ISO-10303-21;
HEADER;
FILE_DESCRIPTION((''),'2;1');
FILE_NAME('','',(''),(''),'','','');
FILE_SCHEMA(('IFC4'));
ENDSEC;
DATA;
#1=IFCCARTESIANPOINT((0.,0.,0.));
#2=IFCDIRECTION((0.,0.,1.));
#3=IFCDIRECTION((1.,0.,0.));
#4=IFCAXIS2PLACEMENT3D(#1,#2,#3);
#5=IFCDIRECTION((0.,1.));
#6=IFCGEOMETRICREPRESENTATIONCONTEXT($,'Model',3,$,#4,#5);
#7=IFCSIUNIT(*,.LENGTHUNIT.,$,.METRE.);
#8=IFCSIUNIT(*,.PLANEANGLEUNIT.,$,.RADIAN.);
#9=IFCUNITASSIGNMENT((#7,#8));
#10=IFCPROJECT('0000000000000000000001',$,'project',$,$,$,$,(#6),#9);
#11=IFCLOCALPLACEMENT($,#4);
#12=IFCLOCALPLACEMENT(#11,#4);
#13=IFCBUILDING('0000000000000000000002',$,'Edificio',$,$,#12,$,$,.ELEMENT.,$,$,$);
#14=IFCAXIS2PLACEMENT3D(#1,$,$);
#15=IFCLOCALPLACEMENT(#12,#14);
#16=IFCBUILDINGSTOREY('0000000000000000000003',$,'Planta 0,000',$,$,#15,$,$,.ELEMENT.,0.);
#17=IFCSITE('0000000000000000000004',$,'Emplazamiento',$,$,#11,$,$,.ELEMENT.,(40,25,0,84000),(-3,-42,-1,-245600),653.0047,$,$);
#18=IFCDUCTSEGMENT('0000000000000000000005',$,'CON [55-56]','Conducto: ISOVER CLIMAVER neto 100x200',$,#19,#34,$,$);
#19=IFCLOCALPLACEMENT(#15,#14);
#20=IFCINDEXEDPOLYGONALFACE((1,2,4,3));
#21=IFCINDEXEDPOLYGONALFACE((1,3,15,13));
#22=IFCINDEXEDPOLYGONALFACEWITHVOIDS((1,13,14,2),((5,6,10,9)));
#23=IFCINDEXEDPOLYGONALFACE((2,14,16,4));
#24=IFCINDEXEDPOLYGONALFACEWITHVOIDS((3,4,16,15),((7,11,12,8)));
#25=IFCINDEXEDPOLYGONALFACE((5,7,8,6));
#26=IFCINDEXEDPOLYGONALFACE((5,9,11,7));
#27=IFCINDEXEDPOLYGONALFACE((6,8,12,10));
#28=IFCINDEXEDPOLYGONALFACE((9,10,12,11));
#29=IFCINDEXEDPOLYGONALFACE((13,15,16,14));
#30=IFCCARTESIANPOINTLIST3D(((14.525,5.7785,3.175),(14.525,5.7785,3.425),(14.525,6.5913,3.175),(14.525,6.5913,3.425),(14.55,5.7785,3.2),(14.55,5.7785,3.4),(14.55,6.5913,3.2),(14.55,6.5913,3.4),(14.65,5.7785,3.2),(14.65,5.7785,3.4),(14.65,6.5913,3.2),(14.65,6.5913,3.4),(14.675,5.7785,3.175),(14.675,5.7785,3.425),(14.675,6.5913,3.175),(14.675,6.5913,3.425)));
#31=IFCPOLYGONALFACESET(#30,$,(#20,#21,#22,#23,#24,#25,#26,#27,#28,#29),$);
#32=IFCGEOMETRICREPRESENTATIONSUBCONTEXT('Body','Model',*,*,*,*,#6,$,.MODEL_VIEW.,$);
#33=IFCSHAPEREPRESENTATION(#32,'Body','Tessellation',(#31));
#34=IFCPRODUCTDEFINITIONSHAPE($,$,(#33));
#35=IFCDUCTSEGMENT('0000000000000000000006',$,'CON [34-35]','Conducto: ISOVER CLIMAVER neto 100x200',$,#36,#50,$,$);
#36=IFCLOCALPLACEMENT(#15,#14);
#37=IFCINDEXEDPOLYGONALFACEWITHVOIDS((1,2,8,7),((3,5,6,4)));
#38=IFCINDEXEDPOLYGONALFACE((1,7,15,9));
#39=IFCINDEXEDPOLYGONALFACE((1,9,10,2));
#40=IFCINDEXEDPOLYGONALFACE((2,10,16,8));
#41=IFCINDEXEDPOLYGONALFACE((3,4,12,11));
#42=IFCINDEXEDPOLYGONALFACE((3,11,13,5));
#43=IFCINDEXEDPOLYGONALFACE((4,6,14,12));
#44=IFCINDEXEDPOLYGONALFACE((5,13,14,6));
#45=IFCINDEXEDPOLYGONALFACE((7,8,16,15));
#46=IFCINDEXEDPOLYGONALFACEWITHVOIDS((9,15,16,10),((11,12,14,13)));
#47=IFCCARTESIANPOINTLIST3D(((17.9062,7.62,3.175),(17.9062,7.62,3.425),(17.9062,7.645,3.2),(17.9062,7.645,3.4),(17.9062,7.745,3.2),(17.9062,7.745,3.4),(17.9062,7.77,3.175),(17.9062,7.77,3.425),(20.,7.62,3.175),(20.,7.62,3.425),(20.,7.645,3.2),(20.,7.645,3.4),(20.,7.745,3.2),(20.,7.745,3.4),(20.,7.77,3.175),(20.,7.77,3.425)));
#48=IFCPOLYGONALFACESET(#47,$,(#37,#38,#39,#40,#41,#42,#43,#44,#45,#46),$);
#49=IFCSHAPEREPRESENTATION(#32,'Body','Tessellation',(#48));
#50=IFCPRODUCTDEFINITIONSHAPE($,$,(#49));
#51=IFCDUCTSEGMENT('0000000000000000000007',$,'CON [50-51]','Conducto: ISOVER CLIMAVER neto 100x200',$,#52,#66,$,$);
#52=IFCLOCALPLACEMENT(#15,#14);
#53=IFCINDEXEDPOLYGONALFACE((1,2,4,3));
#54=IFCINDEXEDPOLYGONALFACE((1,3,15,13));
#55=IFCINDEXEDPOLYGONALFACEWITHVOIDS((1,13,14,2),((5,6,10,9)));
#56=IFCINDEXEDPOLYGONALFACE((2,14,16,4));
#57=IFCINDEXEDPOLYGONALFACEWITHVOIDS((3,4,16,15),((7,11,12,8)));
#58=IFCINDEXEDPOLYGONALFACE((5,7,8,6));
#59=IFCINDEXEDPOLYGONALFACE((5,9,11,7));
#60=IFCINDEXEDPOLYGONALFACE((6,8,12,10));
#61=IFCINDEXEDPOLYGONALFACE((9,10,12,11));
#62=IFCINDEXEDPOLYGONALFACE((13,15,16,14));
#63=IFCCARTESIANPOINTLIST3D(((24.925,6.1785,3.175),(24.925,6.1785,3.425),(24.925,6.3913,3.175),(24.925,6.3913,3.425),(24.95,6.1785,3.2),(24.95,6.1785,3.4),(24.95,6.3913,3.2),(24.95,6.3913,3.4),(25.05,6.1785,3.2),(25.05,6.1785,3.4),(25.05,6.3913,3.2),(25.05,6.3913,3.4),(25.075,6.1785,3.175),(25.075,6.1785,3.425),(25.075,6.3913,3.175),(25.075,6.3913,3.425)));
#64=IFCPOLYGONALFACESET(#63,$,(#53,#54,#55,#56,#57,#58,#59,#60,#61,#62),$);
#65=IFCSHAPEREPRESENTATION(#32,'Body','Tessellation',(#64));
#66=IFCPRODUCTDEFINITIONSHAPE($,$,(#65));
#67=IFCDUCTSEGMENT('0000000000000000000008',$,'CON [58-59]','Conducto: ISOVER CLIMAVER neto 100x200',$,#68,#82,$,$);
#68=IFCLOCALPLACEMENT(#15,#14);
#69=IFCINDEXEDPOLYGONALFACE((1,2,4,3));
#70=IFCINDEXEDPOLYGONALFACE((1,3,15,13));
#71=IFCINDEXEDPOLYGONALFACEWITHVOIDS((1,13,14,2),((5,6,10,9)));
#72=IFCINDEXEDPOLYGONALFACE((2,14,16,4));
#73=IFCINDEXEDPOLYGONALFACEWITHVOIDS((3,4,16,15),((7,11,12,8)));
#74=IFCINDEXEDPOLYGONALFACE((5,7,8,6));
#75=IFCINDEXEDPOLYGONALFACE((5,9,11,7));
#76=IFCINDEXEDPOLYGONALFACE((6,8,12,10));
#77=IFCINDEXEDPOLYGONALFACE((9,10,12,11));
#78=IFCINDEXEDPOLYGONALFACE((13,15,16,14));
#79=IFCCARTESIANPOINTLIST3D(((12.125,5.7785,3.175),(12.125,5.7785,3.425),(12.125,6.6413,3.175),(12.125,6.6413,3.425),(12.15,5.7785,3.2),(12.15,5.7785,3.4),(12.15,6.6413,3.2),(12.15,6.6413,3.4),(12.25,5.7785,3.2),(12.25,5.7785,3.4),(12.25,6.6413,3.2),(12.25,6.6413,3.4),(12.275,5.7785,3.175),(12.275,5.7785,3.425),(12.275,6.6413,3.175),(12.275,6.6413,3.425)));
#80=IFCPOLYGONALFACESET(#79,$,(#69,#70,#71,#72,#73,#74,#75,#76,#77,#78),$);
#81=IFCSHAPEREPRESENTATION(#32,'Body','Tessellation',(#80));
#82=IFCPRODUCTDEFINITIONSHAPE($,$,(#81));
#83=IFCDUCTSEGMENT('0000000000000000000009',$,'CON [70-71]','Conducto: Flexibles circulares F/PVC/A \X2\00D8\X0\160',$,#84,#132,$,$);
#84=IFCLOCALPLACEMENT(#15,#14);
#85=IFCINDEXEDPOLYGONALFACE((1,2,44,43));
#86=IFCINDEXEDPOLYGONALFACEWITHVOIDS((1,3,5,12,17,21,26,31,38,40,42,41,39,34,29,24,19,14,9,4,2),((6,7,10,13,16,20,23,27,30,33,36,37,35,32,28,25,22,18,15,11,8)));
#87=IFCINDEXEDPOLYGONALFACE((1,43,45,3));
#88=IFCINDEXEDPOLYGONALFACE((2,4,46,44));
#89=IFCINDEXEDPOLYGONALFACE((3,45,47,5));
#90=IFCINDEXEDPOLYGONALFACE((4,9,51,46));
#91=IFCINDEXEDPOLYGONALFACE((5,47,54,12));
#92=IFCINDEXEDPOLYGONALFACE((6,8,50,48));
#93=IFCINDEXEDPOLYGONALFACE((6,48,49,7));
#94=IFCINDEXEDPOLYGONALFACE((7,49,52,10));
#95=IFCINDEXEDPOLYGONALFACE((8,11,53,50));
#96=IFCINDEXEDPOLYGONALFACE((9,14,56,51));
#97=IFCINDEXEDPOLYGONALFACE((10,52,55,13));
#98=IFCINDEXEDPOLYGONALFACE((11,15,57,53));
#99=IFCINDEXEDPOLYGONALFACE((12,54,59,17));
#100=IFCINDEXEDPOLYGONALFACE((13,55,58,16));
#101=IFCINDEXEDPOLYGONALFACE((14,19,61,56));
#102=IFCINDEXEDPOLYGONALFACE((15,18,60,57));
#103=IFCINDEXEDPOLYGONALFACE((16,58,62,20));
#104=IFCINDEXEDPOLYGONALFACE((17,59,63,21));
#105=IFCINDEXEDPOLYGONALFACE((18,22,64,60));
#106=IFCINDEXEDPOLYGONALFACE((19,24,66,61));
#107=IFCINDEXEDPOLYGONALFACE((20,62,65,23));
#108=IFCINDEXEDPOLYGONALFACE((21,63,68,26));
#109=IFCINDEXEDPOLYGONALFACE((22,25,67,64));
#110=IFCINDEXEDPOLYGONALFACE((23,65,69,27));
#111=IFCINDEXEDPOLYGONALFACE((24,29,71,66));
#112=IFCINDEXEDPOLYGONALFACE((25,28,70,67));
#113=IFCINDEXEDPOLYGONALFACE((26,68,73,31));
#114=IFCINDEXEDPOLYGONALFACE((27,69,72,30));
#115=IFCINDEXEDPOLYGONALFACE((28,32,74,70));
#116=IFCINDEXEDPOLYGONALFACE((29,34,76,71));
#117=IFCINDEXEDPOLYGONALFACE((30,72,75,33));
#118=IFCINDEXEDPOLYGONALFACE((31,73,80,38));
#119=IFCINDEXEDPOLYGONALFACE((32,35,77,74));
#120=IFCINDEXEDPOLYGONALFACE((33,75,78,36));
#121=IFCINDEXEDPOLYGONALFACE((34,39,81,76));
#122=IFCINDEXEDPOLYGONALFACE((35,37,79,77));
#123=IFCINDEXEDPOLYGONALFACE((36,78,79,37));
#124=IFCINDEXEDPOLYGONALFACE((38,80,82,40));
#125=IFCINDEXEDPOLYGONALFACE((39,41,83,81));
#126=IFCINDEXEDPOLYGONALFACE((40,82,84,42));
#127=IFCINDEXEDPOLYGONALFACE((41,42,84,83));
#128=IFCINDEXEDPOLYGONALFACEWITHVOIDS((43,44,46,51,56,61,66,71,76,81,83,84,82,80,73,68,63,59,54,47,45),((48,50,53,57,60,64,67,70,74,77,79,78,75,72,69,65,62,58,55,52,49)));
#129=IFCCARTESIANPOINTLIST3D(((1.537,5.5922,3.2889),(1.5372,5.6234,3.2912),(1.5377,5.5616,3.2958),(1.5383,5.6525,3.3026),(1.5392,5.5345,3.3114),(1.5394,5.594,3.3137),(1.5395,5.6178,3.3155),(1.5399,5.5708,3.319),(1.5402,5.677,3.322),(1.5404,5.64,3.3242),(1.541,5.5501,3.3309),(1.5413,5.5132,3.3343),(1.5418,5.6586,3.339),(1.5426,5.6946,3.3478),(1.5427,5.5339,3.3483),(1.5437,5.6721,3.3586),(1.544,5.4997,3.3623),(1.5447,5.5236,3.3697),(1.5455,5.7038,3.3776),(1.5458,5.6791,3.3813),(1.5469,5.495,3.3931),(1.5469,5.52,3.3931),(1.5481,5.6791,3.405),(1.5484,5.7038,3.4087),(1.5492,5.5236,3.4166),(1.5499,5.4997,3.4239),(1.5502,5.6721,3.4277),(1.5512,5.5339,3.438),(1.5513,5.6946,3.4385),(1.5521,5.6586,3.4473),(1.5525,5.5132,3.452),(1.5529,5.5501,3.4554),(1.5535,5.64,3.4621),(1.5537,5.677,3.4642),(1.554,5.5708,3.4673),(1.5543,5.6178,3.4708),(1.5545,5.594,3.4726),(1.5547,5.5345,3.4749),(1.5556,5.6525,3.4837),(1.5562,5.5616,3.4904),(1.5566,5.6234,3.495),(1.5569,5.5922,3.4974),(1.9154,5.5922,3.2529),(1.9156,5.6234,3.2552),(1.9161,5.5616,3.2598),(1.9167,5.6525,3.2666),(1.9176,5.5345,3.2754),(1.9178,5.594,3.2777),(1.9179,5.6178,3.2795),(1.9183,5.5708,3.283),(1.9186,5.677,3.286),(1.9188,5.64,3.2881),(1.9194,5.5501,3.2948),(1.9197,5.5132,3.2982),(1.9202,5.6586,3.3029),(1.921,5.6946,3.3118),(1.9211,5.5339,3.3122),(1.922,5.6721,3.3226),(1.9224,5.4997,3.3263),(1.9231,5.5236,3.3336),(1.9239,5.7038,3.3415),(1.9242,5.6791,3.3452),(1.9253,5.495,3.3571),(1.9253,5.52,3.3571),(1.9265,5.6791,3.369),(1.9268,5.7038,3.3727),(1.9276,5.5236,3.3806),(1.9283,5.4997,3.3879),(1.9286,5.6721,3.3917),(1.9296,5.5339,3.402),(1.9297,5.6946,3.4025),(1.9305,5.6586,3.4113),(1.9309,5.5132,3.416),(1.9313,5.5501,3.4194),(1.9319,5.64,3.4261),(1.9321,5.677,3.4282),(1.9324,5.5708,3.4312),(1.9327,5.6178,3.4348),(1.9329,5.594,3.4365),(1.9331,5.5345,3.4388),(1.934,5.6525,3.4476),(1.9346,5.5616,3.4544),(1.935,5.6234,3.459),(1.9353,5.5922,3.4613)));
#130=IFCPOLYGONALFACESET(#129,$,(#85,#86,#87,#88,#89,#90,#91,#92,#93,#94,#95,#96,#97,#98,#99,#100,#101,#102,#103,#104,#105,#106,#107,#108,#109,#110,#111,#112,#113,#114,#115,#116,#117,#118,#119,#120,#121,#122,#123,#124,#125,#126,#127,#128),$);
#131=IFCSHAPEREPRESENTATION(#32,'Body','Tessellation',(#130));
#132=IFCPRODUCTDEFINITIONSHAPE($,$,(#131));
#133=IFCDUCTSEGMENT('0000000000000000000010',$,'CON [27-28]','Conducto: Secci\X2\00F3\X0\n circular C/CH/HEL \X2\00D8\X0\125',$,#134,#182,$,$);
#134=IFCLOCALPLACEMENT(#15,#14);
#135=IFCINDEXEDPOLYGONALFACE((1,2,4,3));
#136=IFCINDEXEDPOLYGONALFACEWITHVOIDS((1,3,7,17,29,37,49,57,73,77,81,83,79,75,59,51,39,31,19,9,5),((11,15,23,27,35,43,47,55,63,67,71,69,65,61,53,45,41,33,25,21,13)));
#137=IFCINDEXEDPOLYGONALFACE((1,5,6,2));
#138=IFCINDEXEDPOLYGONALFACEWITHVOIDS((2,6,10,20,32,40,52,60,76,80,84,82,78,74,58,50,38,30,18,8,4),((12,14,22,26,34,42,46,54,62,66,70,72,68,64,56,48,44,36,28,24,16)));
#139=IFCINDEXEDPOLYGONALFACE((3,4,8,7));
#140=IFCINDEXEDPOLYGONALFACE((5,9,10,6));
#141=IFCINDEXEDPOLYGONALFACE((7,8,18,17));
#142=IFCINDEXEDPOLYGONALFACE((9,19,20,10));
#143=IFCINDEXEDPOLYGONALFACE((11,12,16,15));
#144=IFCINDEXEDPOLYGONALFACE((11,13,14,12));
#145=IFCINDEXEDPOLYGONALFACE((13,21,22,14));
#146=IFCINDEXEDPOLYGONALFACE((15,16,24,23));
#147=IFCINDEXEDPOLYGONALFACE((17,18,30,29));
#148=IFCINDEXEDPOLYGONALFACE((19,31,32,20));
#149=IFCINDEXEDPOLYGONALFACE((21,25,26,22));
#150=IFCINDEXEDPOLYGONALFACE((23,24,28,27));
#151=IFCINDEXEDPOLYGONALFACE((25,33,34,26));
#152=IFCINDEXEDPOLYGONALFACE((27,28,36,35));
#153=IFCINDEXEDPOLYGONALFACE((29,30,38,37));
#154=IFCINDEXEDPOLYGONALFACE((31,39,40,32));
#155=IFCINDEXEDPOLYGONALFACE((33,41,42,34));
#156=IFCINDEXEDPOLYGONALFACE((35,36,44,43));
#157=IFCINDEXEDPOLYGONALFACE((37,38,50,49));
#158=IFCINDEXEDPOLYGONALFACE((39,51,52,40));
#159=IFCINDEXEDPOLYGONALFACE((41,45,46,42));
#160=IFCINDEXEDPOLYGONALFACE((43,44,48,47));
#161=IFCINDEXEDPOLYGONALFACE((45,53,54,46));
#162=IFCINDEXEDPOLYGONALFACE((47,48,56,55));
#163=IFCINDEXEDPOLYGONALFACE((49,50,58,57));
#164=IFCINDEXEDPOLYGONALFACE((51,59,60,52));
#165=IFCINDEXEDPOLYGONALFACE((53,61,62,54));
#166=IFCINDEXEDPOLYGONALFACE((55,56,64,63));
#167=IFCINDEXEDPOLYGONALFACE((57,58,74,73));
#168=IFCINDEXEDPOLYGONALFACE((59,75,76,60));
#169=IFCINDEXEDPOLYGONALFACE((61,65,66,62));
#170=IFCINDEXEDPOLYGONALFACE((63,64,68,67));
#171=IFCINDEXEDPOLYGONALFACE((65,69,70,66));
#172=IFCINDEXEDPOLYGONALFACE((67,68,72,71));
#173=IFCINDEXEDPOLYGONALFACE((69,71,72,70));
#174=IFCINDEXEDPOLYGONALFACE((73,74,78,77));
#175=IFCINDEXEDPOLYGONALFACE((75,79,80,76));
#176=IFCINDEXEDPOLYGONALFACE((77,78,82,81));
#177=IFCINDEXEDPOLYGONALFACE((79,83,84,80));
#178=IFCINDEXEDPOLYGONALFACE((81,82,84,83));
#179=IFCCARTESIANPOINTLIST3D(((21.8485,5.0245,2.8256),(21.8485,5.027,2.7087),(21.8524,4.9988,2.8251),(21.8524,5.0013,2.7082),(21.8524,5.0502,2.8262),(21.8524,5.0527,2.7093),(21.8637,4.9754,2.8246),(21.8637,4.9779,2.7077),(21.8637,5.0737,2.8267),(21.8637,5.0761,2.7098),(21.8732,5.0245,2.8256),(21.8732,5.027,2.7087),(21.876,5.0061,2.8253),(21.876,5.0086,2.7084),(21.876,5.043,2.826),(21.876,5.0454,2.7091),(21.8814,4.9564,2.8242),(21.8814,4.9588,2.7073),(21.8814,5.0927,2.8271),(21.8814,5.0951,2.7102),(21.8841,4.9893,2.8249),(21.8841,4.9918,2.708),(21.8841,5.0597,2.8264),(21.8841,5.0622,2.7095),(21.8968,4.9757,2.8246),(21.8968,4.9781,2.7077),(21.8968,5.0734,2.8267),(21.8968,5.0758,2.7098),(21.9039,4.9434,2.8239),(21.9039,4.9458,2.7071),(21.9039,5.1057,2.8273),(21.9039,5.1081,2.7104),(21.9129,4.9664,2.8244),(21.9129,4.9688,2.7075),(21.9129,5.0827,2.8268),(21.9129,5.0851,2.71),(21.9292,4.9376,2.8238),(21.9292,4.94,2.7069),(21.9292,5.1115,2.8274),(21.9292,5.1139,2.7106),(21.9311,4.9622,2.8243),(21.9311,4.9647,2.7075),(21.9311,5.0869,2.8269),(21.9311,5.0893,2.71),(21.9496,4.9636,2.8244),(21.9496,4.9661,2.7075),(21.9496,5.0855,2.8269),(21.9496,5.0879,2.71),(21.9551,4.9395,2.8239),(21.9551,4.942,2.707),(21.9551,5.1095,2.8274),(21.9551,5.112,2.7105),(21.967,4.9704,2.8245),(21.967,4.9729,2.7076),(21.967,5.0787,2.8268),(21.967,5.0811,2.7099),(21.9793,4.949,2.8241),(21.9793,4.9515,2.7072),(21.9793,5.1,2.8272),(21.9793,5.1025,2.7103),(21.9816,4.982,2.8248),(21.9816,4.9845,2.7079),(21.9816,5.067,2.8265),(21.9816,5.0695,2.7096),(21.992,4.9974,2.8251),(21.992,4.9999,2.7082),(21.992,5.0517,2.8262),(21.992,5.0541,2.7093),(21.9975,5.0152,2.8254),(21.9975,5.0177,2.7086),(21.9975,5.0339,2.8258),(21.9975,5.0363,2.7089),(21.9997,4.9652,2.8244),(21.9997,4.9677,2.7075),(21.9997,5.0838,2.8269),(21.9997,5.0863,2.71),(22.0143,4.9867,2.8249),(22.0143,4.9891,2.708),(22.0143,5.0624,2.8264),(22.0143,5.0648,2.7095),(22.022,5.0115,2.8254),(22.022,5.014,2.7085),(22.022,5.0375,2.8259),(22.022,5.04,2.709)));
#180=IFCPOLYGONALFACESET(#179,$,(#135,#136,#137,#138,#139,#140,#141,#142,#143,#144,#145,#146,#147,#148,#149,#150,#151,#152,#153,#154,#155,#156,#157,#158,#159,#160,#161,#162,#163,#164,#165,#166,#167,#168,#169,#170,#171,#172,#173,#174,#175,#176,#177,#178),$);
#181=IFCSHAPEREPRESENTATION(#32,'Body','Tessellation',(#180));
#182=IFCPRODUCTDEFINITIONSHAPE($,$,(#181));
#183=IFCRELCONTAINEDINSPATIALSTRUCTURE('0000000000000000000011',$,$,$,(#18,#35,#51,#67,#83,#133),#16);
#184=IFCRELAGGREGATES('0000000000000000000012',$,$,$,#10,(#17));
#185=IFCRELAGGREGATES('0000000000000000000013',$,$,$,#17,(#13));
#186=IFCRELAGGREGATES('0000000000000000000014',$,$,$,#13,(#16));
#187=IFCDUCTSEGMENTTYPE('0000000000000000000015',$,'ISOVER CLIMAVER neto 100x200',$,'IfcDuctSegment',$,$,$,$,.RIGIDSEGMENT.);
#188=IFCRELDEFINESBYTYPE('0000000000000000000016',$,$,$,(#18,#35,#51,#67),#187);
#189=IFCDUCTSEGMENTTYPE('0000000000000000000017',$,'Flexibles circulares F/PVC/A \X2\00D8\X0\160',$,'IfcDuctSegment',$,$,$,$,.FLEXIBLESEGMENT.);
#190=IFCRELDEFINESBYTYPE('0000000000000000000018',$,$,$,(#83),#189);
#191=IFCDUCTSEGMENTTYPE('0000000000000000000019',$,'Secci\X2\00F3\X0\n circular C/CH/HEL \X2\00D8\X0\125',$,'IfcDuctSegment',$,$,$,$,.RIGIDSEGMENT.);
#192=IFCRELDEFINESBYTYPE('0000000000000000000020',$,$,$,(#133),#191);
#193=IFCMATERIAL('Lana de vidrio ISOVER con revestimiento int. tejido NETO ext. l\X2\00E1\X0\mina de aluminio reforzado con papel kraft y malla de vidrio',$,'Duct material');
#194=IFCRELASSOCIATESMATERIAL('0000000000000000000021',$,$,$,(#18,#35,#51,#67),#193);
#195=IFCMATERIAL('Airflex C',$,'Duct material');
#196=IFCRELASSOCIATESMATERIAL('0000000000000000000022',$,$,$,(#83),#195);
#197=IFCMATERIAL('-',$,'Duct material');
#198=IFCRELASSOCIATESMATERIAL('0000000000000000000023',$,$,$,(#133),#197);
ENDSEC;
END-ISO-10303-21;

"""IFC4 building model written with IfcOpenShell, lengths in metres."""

from ifc_helpers import new_model, si_unit, direction, frame, origin, origin_with_axes, origin_2d_with_axis, place, context, subcontext, project, spatial, hollow_rectangle, hollow_circle, extrude, material, type_object, element, save


model = new_model("IFC4")

# Units and contexts
model_context = context("Model", 3, world=origin_with_axes(), true_north=direction((0.0, 1.0)))
body_context = subcontext(model_context, "Body", "Model", "MODEL_VIEW")
ifc_project = project(units=[si_unit("LENGTHUNIT", "METRE"), si_unit("PLANEANGLEUNIT", "RADIAN")], contexts=[model_context])

# Site, building, storey
site_placement = place(None, origin_with_axes())
site = spatial("IfcSite", under=ifc_project, at=site_placement, Name="Emplazamiento", CompositionType="ELEMENT", RefLatitude=(40, 25, 0, 84000), RefLongitude=(-3, -42, -1, -245600), RefElevation=653.0047)
building_placement = place(site_placement, origin_with_axes())
building = spatial("IfcBuilding", under=site, at=building_placement, Name="Edificio", CompositionType="ELEMENT")
storey_placement = place(building_placement, origin())
storey = spatial("IfcBuildingStorey", under=building, at=storey_placement, Name="Planta 0,000", CompositionType="ELEMENT", Elevation=0.0)

# Shared definitions
ifc_material_1 = material(Name="-", Category="Duct material")

# Duct segments
ifc_material_2 = material(Name="Lana de vidrio ISOVER con revestimiento int. tejido NETO ext. lámina de aluminio reforzado con papel kraft y malla de vidrio", Category="Duct material")
duct_segment_type_1 = type_object("IfcDuctSegmentType", Name="ISOVER CLIMAVER neto 100x200", ApplicableOccurrence="IfcDuctSegment", PredefinedType="RIGIDSEGMENT")
duct_segment_1_placement = place(storey_placement, origin_with_axes())
element("IfcDuctSegment", 1, at=duct_segment_1_placement, inside=storey, type_object=duct_segment_type_1, material=ifc_material_2, Name="CON [55-56]", Description="Conducto: ISOVER CLIMAVER neto 100x200", context=body_context, shape_type="SweptSolid", body=[
    extrude(hollow_rectangle(XDim=0.15, YDim=0.25, WallThickness=0.025, at=origin_2d_with_axis()), frame((14.6, 6.5913, 3.3), z_axis=(0.0, -1.0, 0.0), x_axis=(1.0, 0.0, 0.0)), (0.0, 0.0, 1.0), 0.8128),
])
duct_segment_2_placement = place(storey_placement, origin_with_axes())
element("IfcDuctSegment", 2, at=duct_segment_2_placement, inside=storey, type_object=duct_segment_type_1, material=ifc_material_2, Name="CON [34-35]", Description="Conducto: ISOVER CLIMAVER neto 100x200", context=body_context, shape_type="SweptSolid", body=[
    extrude(hollow_rectangle(XDim=0.15, YDim=0.25, WallThickness=0.025, at=origin_2d_with_axis()), frame((20.0, 7.695, 3.3), z_axis=(-1.0, 0.0, 0.0), x_axis=(0.0, -1.0, 0.0)), (0.0, 0.0, 1.0), 2.0937),
])
duct_segment_3_placement = place(storey_placement, origin_with_axes())
element("IfcDuctSegment", 3, at=duct_segment_3_placement, inside=storey, type_object=duct_segment_type_1, material=ifc_material_2, Name="CON [50-51]", Description="Conducto: ISOVER CLIMAVER neto 100x200", context=body_context, shape_type="SweptSolid", body=[
    extrude(hollow_rectangle(XDim=0.15, YDim=0.25, WallThickness=0.025, at=origin_2d_with_axis()), frame((25.0, 6.3913, 3.3), z_axis=(0.0, -1.0, 0.0), x_axis=(1.0, 0.0, 0.0)), (0.0, 0.0, 1.0), 0.2128),
])
duct_segment_4_placement = place(storey_placement, origin_with_axes())
element("IfcDuctSegment", 4, at=duct_segment_4_placement, inside=storey, type_object=duct_segment_type_1, material=ifc_material_2, Name="CON [58-59]", Description="Conducto: ISOVER CLIMAVER neto 100x200", context=body_context, shape_type="SweptSolid", body=[
    extrude(hollow_rectangle(XDim=0.15, YDim=0.25, WallThickness=0.025, at=origin_2d_with_axis()), frame((12.2, 6.6413, 3.3), z_axis=(0.0, -1.0, 0.0), x_axis=(1.0, 0.0, 0.0)), (0.0, 0.0, 1.0), 0.8628),
])
ifc_material_3 = material(Name="Airflex C", Category="Duct material")
duct_segment_type_2 = type_object("IfcDuctSegmentType", Name="Flexibles circulares F/PVC/A Ø160", ApplicableOccurrence="IfcDuctSegment", PredefinedType="FLEXIBLESEGMENT")
duct_segment_5_placement = place(storey_placement, origin_with_axes())
element("IfcDuctSegment", 5, at=duct_segment_5_placement, inside=storey, type_object=duct_segment_type_2, material=ifc_material_3, Name="CON [70-71]", Description="Conducto: Flexibles circulares F/PVC/A Ø160", context=body_context, shape_type="SweptSolid", body=[
    extrude(hollow_circle(Radius=0.105, WallThickness=0.025, at=origin_2d_with_axis()), frame((1.9253, 5.6, 3.3571), z_axis=(-0.995498, 0.0, 0.094784), x_axis=(0.0, -1.0, 0.0)), (0.0, 0.0, 1.0), 0.3801),
])
duct_segment_type_3 = type_object("IfcDuctSegmentType", Name="Sección circular C/CH/HEL Ø125", ApplicableOccurrence="IfcDuctSegment", PredefinedType="RIGIDSEGMENT")
duct_segment_6_placement = place(storey_placement, origin_with_axes())
element("IfcDuctSegment", 6, at=duct_segment_6_placement, inside=storey, type_object=duct_segment_type_3, material=ifc_material_1, Name="CON [27-28]", Description="Conducto: Sección circular C/CH/HEL Ø125", context=body_context, shape_type="SweptSolid", body=[
    extrude(hollow_circle(Radius=0.0872, WallThickness=0.0247, at=origin_2d_with_axis()), frame((21.9357, 5.0245, 2.8256), z_axis=(0.0, 0.020817, -0.999783), x_axis=(-1.0, 0.0, 0.0)), (0.0, 0.0, 1.0), 0.1169),
])

save(model, "model.ifc")
